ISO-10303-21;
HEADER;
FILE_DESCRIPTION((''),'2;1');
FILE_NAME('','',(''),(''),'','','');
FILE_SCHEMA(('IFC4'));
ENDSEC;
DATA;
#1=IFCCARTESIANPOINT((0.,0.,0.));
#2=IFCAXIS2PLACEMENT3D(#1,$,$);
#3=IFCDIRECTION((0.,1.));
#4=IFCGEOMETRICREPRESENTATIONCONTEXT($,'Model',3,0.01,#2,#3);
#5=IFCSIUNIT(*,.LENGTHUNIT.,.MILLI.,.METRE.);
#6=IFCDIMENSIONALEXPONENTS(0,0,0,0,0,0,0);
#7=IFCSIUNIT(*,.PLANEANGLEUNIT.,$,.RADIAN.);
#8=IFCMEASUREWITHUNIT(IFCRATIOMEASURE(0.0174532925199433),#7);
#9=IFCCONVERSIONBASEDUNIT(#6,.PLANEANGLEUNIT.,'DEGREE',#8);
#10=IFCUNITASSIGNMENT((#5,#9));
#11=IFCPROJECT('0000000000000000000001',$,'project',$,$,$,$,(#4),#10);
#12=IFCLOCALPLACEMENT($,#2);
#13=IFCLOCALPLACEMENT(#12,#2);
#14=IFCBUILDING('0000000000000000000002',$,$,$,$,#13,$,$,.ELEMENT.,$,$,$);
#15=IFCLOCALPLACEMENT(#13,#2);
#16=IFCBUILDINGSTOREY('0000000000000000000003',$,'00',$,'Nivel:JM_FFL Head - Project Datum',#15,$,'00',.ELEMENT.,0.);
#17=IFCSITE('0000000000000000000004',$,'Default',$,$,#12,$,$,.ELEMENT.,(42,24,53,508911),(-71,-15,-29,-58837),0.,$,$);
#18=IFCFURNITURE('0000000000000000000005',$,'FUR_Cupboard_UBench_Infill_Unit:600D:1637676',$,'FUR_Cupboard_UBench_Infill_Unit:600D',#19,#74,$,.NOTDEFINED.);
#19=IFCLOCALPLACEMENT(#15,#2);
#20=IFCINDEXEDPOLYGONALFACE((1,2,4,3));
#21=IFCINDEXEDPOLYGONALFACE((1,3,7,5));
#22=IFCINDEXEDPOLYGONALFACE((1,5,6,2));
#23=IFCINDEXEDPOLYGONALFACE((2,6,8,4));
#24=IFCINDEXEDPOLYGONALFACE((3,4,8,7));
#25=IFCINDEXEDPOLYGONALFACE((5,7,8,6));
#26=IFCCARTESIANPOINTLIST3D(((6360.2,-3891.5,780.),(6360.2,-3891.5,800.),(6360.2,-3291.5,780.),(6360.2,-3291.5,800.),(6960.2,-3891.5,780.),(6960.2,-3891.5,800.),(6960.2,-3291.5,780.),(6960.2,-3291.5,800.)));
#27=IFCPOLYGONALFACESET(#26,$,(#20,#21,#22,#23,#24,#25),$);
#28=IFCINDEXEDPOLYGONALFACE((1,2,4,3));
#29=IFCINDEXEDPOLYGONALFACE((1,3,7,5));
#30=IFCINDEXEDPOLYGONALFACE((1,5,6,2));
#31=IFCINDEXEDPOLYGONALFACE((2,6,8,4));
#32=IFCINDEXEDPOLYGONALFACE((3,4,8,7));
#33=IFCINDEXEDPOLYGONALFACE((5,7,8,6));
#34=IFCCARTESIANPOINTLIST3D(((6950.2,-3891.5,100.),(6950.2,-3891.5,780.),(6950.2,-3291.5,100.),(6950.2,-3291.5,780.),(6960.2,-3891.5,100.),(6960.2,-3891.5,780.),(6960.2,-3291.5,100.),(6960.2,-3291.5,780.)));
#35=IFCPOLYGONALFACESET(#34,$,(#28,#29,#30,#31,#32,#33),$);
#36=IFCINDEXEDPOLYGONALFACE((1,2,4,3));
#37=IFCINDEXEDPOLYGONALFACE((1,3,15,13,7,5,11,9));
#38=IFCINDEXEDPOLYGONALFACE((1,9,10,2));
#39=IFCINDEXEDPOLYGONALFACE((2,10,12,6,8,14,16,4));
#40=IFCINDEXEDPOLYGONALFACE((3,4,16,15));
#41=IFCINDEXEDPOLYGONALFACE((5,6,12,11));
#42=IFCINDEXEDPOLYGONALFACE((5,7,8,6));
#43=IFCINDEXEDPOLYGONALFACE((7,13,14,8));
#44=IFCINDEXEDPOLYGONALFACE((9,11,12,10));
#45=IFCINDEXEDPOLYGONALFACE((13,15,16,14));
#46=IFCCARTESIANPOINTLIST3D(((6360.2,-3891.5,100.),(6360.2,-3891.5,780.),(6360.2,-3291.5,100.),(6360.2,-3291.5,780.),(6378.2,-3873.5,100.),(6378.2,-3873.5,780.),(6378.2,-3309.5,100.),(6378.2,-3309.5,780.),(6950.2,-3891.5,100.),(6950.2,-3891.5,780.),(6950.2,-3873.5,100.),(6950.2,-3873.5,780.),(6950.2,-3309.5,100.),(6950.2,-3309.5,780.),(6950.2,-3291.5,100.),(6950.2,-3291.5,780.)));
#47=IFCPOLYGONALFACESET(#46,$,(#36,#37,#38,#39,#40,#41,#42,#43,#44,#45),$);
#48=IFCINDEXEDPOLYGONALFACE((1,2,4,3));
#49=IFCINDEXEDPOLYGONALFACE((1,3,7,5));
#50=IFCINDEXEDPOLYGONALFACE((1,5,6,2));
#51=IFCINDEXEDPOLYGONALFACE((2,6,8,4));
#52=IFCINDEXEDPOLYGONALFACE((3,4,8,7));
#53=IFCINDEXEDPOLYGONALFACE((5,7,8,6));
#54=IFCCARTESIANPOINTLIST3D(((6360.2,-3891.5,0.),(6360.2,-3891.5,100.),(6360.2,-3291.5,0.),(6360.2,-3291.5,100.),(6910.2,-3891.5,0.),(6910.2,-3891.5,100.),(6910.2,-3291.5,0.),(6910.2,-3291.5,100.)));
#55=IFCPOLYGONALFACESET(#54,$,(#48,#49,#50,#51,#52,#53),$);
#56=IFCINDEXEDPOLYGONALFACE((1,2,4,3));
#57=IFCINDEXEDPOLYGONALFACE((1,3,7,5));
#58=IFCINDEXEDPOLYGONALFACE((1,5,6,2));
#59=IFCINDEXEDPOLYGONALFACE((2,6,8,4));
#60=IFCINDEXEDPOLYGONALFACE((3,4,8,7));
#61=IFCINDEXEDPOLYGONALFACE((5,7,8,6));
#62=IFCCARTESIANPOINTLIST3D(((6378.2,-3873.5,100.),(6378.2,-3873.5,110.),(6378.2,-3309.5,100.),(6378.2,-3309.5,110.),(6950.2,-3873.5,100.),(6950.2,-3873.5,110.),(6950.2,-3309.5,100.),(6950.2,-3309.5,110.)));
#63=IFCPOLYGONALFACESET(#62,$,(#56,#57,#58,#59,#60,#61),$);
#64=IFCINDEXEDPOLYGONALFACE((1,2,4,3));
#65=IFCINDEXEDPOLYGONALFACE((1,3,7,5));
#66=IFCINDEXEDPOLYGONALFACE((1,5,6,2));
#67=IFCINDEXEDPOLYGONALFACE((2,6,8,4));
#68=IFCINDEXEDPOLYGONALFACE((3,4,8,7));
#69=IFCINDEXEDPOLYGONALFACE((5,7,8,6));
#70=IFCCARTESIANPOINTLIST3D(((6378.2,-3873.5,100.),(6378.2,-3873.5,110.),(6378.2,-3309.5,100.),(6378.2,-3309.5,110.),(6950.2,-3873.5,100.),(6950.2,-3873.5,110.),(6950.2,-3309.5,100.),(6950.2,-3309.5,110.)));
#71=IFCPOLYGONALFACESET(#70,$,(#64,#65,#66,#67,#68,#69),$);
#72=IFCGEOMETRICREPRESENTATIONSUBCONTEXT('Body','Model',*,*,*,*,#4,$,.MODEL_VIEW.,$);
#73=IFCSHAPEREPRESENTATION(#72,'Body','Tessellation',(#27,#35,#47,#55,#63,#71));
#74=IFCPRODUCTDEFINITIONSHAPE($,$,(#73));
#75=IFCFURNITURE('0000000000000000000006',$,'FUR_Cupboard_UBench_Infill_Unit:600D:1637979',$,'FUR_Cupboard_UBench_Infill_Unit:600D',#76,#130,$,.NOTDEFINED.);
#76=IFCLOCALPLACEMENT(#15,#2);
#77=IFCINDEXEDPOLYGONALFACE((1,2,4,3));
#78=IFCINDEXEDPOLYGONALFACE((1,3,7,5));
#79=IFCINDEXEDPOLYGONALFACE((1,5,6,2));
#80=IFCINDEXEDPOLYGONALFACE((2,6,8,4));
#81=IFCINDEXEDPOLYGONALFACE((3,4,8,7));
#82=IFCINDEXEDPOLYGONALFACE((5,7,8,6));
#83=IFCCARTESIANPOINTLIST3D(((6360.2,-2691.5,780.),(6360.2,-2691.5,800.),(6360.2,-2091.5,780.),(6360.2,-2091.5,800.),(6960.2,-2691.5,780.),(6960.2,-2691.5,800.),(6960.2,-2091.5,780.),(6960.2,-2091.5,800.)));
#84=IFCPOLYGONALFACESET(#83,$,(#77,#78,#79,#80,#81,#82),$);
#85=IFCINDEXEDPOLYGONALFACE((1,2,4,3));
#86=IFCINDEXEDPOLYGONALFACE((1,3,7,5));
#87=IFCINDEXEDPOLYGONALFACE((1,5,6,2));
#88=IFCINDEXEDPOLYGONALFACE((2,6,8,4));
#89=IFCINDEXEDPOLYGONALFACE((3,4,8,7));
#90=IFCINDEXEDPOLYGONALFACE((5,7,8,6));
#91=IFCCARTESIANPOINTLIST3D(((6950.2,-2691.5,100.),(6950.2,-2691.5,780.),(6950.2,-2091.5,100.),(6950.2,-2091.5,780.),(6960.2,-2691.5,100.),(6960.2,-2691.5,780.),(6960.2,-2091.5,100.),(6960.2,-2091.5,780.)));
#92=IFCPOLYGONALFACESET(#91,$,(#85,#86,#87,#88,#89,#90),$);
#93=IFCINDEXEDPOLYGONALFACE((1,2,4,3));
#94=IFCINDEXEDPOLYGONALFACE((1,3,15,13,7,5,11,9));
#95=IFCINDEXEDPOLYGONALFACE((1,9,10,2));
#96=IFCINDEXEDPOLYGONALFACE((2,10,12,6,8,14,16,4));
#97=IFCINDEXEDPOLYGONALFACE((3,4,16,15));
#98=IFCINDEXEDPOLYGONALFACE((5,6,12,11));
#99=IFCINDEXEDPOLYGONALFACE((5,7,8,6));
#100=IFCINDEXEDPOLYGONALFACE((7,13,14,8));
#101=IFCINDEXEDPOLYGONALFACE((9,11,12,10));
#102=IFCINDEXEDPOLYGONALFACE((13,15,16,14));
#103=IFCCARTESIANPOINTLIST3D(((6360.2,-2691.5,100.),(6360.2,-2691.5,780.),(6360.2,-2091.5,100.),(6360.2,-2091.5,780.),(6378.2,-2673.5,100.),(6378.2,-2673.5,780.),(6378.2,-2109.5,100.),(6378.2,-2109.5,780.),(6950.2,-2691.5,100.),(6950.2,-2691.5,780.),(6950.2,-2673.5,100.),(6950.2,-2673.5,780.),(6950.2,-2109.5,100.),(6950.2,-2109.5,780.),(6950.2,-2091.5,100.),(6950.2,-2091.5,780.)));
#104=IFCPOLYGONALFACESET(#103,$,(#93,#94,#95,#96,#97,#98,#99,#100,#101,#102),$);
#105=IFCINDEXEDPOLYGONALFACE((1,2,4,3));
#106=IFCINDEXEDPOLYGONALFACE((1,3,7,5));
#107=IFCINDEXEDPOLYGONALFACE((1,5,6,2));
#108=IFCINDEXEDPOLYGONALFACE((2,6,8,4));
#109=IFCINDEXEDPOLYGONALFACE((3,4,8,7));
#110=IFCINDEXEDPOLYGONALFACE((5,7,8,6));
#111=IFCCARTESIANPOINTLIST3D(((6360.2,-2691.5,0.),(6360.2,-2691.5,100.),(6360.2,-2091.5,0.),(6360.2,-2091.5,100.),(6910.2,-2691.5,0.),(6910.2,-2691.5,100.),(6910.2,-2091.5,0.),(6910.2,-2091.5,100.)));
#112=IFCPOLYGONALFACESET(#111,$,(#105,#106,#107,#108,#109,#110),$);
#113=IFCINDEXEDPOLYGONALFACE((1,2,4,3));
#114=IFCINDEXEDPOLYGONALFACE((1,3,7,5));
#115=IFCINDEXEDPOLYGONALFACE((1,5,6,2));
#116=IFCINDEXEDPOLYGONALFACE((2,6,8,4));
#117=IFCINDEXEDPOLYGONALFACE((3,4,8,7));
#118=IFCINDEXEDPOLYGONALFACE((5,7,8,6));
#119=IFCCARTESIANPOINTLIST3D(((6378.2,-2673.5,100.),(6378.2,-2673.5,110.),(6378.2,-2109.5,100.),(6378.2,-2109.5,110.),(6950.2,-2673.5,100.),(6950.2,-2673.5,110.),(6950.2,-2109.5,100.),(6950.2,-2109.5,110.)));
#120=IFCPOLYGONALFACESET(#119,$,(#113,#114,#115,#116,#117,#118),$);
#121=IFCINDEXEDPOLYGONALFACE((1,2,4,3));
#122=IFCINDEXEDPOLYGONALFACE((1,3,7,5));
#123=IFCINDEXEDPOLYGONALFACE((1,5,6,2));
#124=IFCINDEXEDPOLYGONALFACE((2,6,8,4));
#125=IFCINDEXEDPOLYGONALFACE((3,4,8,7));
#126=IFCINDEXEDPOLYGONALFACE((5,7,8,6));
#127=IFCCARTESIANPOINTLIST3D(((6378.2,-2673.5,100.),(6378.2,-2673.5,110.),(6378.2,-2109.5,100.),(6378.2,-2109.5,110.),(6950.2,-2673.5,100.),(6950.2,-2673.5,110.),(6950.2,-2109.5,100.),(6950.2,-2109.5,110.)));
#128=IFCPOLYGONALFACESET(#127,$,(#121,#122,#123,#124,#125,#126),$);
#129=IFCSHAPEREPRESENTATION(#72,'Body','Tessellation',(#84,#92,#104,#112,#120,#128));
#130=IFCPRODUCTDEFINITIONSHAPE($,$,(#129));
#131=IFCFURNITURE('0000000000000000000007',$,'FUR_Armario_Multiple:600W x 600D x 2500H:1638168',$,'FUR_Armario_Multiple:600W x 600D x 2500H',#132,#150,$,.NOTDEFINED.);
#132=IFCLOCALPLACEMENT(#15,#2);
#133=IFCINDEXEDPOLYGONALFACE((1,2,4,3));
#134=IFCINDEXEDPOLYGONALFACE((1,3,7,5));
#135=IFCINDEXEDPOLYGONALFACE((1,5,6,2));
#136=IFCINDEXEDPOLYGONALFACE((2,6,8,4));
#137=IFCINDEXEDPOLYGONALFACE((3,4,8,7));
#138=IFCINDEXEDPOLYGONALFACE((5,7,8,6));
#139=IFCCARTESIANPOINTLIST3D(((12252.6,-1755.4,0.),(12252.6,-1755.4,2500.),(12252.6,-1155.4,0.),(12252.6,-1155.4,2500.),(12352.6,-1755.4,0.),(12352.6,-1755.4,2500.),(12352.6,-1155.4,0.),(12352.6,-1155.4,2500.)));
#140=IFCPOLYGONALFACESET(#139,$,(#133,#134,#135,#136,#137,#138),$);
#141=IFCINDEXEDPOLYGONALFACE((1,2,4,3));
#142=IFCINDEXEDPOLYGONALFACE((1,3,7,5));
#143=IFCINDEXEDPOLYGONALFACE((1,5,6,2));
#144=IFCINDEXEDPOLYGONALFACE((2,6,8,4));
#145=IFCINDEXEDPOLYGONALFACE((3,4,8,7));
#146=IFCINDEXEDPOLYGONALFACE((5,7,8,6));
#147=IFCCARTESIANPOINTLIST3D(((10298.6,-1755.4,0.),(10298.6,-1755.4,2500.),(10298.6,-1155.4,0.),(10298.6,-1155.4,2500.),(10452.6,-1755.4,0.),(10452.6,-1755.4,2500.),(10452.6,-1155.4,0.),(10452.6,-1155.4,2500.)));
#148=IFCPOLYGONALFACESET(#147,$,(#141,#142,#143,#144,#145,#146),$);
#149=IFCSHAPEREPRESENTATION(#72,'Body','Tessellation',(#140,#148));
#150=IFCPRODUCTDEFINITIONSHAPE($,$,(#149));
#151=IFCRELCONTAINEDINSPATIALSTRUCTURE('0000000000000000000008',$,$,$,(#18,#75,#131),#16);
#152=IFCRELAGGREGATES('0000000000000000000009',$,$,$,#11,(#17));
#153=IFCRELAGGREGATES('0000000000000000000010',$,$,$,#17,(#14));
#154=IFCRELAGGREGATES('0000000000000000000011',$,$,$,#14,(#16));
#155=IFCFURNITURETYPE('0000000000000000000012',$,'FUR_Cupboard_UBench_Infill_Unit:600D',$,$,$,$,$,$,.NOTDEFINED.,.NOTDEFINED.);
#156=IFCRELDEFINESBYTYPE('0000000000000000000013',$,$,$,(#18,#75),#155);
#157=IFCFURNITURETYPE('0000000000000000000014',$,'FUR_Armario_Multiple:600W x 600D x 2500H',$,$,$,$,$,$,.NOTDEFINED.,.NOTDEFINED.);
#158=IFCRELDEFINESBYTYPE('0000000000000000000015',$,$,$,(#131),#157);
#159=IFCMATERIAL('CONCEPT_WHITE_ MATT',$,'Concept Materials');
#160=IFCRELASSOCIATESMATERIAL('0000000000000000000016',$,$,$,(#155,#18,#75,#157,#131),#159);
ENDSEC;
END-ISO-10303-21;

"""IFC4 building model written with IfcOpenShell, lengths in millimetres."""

from ifc_helpers import new_model, entity, si_unit, converted_unit, direction, frame, origin, place, context, subcontext, project, spatial, indexed_curve, outline, extrude, source, transform, mapped, material, type_object, type_shapes, element, save


model = new_model("IFC4")

# Units and contexts
model_context = context("Model", 3, precision=0.01, world=origin(), true_north=direction((0.0, 1.0)))
body_context = subcontext(model_context, "Body", "Model", "MODEL_VIEW")
ifc_project = project(units=[si_unit("LENGTHUNIT", "METRE", prefix="MILLI"), converted_unit("PLANEANGLEUNIT", "DEGREE", entity("IfcRatioMeasure", 0.0174532925199433), si_unit("PLANEANGLEUNIT", "RADIAN"), dimensions=[0, 0, 0, 0, 0, 0, 0])], contexts=[model_context])

# Site, building, storey
site_placement = place(None, origin())
site = spatial("IfcSite", under=ifc_project, at=site_placement, Name="Default", CompositionType="ELEMENT", RefLatitude=(42, 24, 53, 508911), RefLongitude=(-71, -15, -29, -58837), RefElevation=0.0)
building_placement = place(site_placement, origin())
building = spatial("IfcBuilding", under=site, at=building_placement, CompositionType="ELEMENT")
storey_placement = place(building_placement, origin())
storey = spatial("IfcBuildingStorey", under=building, at=storey_placement, Name="00", ObjectType="Nivel:JM_FFL Head - Project Datum", LongName="00", CompositionType="ELEMENT", Elevation=0.0)

# Furniture
ifc_material_1 = material(Name="CONCEPT_WHITE_ MATT", Category="Concept Materials")
furniture_type_1 = type_object("IfcFurnitureType", Name="FUR_Cupboard_UBench_Infill_Unit:600D", AssemblyPlace="NOTDEFINED", PredefinedType="NOTDEFINED", material=ifc_material_1)
shared_shape_1 = source(origin(), body_context, "Body", "SweptSolid", [
    extrude(outline(indexed_curve([(-300.0, -300.0), (300.0, -300.0), (300.0, 300.0), (-300.0, 300.0), (-300.0, -300.0)], self_intersect=False)), frame((44.7, -300.0, 780.0), z_axis=(0.0, 0.0, 1.0), x_axis=(-1.0, 0.0, 0.0)), (0.0, 0.0, 1.0), 20.0),
    extrude(outline(indexed_curve([(-300.0, -5.0), (300.0, -5.0), (300.0, 5.0), (-300.0, 5.0), (-300.0, -5.0)], self_intersect=False)), frame((44.7, -595.0, 100.0), z_axis=(0.0, 0.0, 1.0), x_axis=(-1.0, 0.0, 0.0)), (0.0, 0.0, 1.0), 680.0),
    extrude(outline(indexed_curve([(-300.0, -299.5), (300.0, -299.5), (300.0, 290.5), (282.0, 290.5), (282.0, -281.5), (-282.0, -281.5), (-282.0, 290.5), (-300.0, 290.5), (-300.0, -299.5)], self_intersect=False)), frame((44.7, -299.5, 100.0), z_axis=(0.0, 0.0, 1.0), x_axis=(-1.0, 0.0, 0.0)), (0.0, 0.0, 1.0), 680.0),
    extrude(outline(indexed_curve([(-300.0, -275.0), (300.0, -275.0), (300.0, 275.0), (-300.0, 275.0), (-300.0, -275.0)], self_intersect=False)), frame((44.7, -275.0, 0.0), z_axis=(0.0, 0.0, 1.0), x_axis=(-1.0, 0.0, 0.0)), (0.0, 0.0, 1.0), 100.0),
    extrude(outline(indexed_curve([(-282.0, -286.0), (282.0, -286.0), (282.0, 286.0), (-282.0, 286.0), (-282.0, -286.0)], self_intersect=False)), frame((44.7, -304.0, 100.0), z_axis=(0.0, 0.0, 1.0), x_axis=(-1.0, 0.0, 0.0)), (0.0, 0.0, 1.0), 10.0),
    extrude(outline(indexed_curve([(-282.0, -286.0), (282.0, -286.0), (282.0, 286.0), (-282.0, 286.0), (-282.0, -286.0)], self_intersect=False)), frame((44.7, -304.0, 100.0), z_axis=(0.0, 0.0, 1.0), x_axis=(-1.0, 0.0, 0.0)), (0.0, 0.0, 1.0), 10.0),
])
type_shapes(furniture_type_1, [shared_shape_1])
for number, where, z_axis, x_axis, name in (
    (1, (6360.2, -3636.2, 0.0), (0.0, 0.0, 1.0), (0.0, 1.0, 0.0), "FUR_Cupboard_UBench_Infill_Unit:600D:1637676"),
    (2, (6360.2, -2436.2, 0.0), (0.0, 0.0, 1.0), (0.0, 1.0, 0.0), "FUR_Cupboard_UBench_Infill_Unit:600D:1637979"),
):
    element("IfcFurniture", number, at=place(storey_placement, frame(where, z_axis=z_axis, x_axis=x_axis)), inside=storey, type_object=furniture_type_1, material=ifc_material_1, Name=name, ObjectType="FUR_Cupboard_UBench_Infill_Unit:600D", PredefinedType="NOTDEFINED", context=body_context, shape_type="MappedRepresentation", body=[
        mapped(shared_shape_1, transform((0.0, 0.0, 0.0), scale=1.0)),
    ])
furniture_type_2 = type_object("IfcFurnitureType", Name="FUR_Armario_Multiple:600W x 600D x 2500H", AssemblyPlace="NOTDEFINED", PredefinedType="NOTDEFINED", material=ifc_material_1)
shared_shape_2 = source(origin(), body_context, "Body", "SweptSolid", [
    extrude(outline(indexed_curve([(-50.0, -300.0), (50.0, -300.0), (50.0, 300.0), (-50.0, 300.0), (-50.0, -300.0)], self_intersect=False)), frame((1850.0, 300.0, 0.0)), (0.0, 0.0, 1.0), 2500.0),
    extrude(outline(indexed_curve([(-300.0, -77.0), (300.0, -77.0), (300.0, 77.0), (-300.0, 77.0), (-300.0, -77.0)], self_intersect=False)), frame((-77.0, 300.0, 0.0), z_axis=(0.0, 0.0, 1.0), x_axis=(0.0, 1.0, 0.0)), (0.0, 0.0, 1.0), 2500.0),
])
type_shapes(furniture_type_2, [shared_shape_2])
furniture_1_placement = place(storey_placement, frame((10452.6, -1755.4, 0.0)))
element("IfcFurniture", 3, at=furniture_1_placement, inside=storey, type_object=furniture_type_2, material=ifc_material_1, Name="FUR_Armario_Multiple:600W x 600D x 2500H:1638168", ObjectType="FUR_Armario_Multiple:600W x 600D x 2500H", PredefinedType="NOTDEFINED", context=body_context, shape_type="MappedRepresentation", body=[
    mapped(shared_shape_2, transform((0.0, 0.0, 0.0), scale=1.0)),
])

save(model, "model.ifc")
